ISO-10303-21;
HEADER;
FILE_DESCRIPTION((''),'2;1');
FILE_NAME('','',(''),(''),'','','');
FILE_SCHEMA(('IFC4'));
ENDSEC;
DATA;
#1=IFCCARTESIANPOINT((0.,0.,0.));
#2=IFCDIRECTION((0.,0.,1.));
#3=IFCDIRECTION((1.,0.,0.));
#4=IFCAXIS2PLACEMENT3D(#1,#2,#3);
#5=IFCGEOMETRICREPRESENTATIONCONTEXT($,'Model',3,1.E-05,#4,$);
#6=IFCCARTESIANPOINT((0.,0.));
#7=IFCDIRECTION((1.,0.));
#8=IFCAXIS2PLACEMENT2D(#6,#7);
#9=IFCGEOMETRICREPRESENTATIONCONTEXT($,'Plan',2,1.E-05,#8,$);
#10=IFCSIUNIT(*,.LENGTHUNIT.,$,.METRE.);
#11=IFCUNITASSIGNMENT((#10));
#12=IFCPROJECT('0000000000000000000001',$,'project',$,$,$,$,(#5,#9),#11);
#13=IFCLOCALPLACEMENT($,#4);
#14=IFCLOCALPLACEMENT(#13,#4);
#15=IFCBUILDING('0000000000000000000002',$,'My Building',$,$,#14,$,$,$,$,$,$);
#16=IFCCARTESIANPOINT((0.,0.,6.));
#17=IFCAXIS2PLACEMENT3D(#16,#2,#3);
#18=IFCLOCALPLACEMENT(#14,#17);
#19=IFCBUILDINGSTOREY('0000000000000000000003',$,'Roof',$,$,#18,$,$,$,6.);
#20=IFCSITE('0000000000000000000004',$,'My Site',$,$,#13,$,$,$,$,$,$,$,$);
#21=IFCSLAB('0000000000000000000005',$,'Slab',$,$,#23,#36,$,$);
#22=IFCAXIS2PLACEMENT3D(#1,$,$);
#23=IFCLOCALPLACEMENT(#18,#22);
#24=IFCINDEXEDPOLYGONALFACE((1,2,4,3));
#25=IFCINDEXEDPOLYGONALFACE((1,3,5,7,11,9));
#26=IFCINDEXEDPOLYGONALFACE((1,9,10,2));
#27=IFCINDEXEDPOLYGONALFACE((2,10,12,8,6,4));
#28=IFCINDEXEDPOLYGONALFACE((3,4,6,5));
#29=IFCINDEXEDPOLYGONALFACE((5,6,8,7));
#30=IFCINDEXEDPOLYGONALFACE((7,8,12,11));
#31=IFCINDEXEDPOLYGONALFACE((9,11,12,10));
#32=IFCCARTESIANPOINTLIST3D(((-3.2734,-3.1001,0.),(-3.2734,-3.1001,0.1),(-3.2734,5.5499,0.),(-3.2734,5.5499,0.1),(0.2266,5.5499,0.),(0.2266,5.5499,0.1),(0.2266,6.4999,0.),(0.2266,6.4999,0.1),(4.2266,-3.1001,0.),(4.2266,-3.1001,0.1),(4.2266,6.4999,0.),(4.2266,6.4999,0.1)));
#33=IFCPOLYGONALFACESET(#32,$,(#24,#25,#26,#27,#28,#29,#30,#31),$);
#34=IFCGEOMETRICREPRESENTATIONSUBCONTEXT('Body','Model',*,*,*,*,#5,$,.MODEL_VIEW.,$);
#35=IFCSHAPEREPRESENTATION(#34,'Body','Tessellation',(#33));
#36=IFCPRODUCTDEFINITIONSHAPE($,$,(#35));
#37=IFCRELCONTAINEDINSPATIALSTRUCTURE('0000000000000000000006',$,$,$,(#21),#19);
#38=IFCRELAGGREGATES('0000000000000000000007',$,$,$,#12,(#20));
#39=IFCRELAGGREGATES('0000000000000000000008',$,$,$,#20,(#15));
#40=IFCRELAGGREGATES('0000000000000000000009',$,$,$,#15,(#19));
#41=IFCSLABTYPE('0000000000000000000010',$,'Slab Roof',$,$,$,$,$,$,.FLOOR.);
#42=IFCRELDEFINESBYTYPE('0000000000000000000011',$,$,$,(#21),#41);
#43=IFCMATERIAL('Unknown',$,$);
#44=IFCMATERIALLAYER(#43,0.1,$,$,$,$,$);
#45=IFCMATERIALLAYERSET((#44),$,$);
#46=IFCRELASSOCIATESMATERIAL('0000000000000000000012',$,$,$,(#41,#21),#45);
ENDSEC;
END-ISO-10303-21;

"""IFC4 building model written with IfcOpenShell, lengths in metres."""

from ifc_helpers import new_model, si_unit, frame, origin_with_axes, origin_2d_with_axis, place, context, subcontext, project, spatial, polyline, outline, extrude, material, layer, layer_set, layer_usage, type_object, element, save


model = new_model("IFC4")

# Units and contexts
model_context = context("Model", 3, precision=1e-05, world=origin_with_axes())
plan_context = context("Plan", 2, precision=1e-05, world=origin_2d_with_axis())
body_context = subcontext(model_context, "Body", "Model", "MODEL_VIEW")
ifc_project = project(units=[si_unit("LENGTHUNIT", "METRE")], contexts=[model_context, plan_context])

# Site, building, storey
site_placement = place(None, origin_with_axes())
site = spatial("IfcSite", under=ifc_project, at=site_placement, Name="My Site")
building_placement = place(site_placement, origin_with_axes())
building = spatial("IfcBuilding", under=site, at=building_placement, Name="My Building")
storey_placement = place(building_placement, frame((0.0, 0.0, 6.0), z_axis=(0.0, 0.0, 1.0), x_axis=(1.0, 0.0, 0.0)))
storey = spatial("IfcBuildingStorey", under=building, at=storey_placement, Name="Roof", Elevation=6.0)

# Slab
ifc_material = material(Name="Unknown")
ifc_layer = layer(ifc_material, 0.1)
ifc_layer_set = layer_set([ifc_layer])
ifc_layer_usage = layer_usage(ifc_layer_set, "AXIS3", "POSITIVE", -0.1)
slab_type = type_object("IfcSlabType", Name="Slab Roof", PredefinedType="FLOOR", material=ifc_layer_set)
slab_placement = place(storey_placement, frame((0.0, 0.0, 0.1), z_axis=(0.0, 0.0, 1.0), x_axis=(1.0, 0.0, 0.0)))
element("IfcSlab", 1, at=slab_placement, inside=storey, type_object=slab_type, material=ifc_layer_usage, Name="Slab", context=body_context, shape_type="SweptSolid", body=[
    extrude(outline(polyline([(4.2266, -3.1001), (-3.2734, -3.1001), (-3.2734, 5.5499), (0.2266, 5.5499), (0.2266, 6.4999), (4.2266, 6.4999), (4.2266, -3.1001)])), frame((0.0, 0.0, -0.1), z_axis=(0.0, 0.0, 1.0), x_axis=(1.0, 0.0, 0.0)), (0.0, 0.0, 1.0), 0.1),
])

save(model, "model.ifc")
